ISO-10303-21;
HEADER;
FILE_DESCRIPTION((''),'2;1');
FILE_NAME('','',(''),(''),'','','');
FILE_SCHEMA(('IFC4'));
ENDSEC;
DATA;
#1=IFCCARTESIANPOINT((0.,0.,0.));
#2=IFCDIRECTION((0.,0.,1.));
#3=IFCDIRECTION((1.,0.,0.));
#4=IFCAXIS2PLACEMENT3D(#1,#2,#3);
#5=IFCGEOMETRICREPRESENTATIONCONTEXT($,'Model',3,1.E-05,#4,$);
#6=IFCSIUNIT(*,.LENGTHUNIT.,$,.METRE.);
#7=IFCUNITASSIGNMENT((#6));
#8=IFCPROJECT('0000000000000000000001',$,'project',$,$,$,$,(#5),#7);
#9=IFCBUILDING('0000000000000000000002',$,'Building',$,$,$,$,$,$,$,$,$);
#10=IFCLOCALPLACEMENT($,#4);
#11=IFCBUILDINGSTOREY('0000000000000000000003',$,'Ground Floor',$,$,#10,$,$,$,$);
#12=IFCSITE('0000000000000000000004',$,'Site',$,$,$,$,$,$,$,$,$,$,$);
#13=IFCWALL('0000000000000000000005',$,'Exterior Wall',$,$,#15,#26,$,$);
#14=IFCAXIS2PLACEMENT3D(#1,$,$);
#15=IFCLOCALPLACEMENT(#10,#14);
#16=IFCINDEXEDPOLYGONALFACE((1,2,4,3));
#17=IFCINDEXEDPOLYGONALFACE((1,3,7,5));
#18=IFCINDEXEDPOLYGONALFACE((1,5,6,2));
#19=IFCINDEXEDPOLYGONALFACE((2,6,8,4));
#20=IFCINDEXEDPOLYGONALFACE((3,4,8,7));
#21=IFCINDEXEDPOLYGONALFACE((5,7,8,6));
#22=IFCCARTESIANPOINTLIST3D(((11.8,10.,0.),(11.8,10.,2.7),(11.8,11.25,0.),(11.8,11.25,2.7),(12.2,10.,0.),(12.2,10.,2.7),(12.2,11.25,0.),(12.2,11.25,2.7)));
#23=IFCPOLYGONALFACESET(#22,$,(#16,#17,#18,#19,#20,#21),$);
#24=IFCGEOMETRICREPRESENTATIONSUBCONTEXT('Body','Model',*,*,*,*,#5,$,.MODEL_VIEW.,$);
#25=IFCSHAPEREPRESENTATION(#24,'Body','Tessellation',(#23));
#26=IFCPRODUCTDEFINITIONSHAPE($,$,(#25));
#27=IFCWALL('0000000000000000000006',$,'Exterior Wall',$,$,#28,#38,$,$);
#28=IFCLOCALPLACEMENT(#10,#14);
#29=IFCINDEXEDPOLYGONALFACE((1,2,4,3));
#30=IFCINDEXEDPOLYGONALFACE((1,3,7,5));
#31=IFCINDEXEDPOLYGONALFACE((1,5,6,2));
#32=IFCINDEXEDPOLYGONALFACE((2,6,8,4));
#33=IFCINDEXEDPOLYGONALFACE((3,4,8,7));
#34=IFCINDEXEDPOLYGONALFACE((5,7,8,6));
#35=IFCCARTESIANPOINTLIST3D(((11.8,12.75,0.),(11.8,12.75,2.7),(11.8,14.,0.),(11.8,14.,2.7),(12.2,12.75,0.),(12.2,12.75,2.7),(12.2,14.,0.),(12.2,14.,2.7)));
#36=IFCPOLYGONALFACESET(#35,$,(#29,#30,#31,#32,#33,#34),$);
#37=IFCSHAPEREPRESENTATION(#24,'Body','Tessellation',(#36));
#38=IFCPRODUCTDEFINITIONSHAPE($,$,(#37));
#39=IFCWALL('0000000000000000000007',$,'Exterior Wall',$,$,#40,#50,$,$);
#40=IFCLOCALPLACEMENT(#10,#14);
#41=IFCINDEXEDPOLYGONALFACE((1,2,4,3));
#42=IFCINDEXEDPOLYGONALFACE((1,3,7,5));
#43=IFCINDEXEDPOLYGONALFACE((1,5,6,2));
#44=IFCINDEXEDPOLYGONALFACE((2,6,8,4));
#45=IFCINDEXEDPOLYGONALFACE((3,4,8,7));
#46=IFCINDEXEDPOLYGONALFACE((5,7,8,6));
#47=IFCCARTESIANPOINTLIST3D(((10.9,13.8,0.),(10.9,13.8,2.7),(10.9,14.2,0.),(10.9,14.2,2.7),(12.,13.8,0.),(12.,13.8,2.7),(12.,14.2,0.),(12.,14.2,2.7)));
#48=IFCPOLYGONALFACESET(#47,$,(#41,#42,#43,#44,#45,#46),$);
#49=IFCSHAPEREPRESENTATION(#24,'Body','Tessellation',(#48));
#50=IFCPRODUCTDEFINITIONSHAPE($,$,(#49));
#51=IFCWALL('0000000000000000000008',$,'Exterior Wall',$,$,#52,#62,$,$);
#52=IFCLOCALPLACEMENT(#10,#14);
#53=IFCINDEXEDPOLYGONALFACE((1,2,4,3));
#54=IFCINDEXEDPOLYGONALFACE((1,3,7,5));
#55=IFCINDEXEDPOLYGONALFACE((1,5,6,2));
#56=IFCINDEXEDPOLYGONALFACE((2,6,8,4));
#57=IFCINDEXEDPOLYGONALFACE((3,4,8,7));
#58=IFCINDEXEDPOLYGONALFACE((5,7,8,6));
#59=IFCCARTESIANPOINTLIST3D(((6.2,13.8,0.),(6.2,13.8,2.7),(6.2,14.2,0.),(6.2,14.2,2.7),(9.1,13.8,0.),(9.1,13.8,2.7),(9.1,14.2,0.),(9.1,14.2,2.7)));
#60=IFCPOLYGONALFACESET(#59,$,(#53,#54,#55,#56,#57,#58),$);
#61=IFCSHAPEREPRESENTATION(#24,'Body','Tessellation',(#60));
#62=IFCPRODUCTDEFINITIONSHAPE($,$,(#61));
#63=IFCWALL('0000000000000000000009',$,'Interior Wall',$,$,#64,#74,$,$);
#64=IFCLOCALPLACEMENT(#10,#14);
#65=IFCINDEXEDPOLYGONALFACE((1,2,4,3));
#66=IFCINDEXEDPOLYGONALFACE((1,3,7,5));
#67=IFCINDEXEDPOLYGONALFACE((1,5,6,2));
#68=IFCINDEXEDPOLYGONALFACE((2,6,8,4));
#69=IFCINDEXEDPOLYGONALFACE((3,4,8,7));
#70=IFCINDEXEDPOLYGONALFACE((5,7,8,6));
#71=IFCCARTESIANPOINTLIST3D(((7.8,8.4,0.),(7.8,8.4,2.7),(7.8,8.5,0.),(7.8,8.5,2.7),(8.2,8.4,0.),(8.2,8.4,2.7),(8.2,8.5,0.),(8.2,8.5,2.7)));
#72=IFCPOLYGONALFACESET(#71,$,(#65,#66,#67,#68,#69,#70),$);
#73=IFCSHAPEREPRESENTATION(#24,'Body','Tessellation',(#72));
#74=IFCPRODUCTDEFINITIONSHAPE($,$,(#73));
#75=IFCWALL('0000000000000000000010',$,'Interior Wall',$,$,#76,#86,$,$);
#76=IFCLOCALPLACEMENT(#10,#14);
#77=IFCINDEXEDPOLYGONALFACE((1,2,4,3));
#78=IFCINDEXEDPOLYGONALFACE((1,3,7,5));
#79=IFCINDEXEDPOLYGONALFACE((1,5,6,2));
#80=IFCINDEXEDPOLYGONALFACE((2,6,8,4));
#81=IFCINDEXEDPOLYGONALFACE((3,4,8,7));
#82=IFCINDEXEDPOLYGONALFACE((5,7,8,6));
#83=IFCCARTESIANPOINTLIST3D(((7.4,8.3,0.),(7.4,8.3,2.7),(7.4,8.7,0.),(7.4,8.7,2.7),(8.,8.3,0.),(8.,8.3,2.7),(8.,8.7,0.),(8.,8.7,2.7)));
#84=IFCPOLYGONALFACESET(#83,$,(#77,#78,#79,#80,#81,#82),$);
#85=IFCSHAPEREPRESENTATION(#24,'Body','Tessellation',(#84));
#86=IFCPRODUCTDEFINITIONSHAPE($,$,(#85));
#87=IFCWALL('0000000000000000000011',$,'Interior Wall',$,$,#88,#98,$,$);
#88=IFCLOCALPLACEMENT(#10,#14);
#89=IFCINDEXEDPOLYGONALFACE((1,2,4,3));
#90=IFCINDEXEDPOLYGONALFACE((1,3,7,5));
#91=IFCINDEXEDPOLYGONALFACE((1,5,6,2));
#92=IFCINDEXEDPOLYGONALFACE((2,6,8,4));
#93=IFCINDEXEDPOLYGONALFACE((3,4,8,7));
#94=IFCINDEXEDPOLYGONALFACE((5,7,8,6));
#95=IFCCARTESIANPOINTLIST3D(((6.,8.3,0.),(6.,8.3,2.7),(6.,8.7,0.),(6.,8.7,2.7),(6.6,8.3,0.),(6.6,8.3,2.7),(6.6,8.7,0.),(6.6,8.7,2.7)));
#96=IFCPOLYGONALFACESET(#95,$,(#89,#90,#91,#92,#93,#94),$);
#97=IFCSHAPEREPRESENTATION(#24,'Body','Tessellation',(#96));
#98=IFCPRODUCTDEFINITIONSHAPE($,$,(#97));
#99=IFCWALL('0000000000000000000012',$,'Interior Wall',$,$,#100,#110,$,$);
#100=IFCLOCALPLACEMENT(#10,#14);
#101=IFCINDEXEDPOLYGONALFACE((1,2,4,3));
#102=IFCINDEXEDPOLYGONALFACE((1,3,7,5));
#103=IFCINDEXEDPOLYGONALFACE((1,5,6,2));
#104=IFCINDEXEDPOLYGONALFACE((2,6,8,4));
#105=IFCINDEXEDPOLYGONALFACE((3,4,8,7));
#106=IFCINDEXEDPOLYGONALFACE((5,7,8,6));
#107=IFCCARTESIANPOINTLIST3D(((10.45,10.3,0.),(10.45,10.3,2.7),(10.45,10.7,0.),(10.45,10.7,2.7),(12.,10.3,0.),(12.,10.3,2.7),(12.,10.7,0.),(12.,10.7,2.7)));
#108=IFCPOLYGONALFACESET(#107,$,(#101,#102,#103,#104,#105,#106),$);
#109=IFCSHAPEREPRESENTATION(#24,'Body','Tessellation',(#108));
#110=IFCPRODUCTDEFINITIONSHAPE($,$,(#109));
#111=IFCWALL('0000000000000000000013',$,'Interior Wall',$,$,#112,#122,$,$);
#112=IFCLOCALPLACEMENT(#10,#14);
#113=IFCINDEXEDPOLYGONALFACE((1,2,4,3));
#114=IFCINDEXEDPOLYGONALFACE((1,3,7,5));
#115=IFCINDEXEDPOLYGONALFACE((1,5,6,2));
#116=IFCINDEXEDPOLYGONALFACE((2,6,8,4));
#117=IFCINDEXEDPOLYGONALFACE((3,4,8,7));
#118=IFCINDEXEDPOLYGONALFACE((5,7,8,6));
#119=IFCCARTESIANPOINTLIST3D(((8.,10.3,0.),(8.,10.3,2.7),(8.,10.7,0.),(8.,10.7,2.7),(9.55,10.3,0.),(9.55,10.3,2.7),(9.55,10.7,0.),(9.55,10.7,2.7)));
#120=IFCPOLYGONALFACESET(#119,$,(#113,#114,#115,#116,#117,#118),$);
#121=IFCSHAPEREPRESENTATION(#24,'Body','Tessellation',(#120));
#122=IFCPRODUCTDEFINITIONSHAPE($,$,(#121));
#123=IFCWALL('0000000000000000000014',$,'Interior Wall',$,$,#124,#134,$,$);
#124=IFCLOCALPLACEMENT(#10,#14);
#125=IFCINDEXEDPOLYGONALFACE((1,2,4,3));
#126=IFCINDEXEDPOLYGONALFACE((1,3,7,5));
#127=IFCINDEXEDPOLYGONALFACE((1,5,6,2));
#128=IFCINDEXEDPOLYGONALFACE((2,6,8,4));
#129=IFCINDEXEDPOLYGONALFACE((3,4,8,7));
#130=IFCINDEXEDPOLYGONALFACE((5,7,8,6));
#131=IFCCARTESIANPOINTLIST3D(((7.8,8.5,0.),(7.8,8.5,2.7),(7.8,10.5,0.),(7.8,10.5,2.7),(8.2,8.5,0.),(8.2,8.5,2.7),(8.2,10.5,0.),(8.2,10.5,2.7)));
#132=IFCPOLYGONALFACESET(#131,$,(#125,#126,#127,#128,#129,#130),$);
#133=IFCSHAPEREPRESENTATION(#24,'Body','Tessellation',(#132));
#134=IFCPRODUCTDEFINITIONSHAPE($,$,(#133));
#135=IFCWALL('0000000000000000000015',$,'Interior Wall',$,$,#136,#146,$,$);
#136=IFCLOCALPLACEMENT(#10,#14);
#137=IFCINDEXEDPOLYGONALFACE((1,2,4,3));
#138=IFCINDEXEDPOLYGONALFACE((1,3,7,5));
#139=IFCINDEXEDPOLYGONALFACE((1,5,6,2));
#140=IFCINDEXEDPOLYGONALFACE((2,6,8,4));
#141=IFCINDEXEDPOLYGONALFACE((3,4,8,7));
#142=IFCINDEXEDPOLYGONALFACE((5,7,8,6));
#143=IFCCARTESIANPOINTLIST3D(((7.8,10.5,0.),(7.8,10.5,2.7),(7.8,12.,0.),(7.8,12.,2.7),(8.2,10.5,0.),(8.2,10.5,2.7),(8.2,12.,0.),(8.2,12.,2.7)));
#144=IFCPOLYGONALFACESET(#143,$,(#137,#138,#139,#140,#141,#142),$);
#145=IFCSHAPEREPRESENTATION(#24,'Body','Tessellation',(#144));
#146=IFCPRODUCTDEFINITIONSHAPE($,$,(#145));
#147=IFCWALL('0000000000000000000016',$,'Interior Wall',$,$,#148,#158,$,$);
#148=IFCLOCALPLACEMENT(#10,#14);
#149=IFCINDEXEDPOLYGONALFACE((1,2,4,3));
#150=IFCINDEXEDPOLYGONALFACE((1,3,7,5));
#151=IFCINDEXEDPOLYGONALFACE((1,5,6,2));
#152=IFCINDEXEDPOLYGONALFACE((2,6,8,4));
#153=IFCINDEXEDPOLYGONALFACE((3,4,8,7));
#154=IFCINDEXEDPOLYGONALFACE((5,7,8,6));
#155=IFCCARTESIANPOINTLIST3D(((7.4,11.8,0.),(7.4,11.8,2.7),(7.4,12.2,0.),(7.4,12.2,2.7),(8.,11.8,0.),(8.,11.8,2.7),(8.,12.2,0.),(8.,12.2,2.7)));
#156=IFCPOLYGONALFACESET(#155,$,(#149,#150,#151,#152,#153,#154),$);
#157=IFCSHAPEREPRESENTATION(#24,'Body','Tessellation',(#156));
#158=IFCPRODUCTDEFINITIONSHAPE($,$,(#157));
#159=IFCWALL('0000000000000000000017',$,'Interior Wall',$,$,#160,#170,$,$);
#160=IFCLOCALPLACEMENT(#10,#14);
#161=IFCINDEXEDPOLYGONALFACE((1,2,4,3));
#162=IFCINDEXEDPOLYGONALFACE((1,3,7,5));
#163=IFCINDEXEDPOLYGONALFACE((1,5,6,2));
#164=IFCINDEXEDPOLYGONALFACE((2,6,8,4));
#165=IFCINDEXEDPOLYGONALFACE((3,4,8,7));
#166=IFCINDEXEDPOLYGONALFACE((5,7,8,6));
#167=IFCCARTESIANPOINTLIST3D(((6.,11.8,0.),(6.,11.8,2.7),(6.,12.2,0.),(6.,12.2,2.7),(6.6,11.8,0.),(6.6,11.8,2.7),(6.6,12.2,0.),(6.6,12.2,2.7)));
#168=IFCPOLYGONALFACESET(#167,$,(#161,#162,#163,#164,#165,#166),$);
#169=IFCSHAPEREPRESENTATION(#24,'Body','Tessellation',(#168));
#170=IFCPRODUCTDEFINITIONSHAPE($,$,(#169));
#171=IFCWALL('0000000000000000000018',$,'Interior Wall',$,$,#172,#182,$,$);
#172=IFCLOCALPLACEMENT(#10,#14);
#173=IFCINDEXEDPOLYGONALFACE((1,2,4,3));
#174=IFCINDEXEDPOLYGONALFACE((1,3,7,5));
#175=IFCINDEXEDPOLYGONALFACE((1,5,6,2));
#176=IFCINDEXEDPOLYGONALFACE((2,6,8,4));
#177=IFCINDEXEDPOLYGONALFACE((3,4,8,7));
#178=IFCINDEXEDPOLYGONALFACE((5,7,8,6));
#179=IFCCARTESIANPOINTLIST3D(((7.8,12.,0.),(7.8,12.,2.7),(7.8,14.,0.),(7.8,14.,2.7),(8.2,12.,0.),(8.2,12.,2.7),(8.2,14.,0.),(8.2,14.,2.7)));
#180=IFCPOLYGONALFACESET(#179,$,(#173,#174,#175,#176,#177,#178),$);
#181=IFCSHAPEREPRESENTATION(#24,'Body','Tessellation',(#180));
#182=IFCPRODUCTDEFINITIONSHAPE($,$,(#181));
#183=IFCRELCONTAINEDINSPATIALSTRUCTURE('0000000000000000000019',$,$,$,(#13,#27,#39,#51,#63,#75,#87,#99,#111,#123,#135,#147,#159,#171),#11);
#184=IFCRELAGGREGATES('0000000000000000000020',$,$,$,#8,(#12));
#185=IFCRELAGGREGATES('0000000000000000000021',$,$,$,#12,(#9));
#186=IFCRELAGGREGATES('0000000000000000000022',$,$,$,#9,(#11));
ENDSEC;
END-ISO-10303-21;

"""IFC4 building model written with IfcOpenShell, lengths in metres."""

from ifc_helpers import new_model, si_unit, frame, origin_with_axes, place, context, subcontext, project, spatial, indexed_curve, outline, extrude, element, save


model = new_model("IFC4")

# Units and contexts
model_context = context("Model", 3, precision=1e-05, world=origin_with_axes())
body_context = subcontext(model_context, "Body", "Model", "MODEL_VIEW")
ifc_project = project(units=[si_unit("LENGTHUNIT", "METRE")], contexts=[model_context])

# Site, building, storey
site = spatial("IfcSite", under=ifc_project, Name="Site")
building = spatial("IfcBuilding", under=site, Name="Building")
storey_placement = place(None, origin_with_axes())
storey = spatial("IfcBuildingStorey", under=building, at=storey_placement, Name="Ground Floor")

# Walls
for number, where, z_axis, x_axis, name in (
    (1, (12.0, 10.0, 0.0), (0.0, 0.0, 1.0), (0.0, 1.0, 0.0), "Exterior Wall"),
    (2, (12.0, 12.75, 0.0), (0.0, 0.0, 1.0), (0.0, 1.0, 0.0), "Exterior Wall"),
):
    element("IfcWall", number, at=place(storey_placement, frame(where, z_axis=z_axis, x_axis=x_axis)), inside=storey, Name=name, context=body_context, shape_type="SweptSolid", body=[
        extrude(outline(indexed_curve([(0.0, 0.0), (0.0, 0.4), (1.25, 0.4), (1.25, 0.0), (0.0, 0.0)], self_intersect=False)), frame((0.0, -0.2, 0.0), z_axis=(0.0, 0.0, 1.0), x_axis=(1.0, 0.0, 0.0)), (0.0, 0.0, 1.0), 2.7),
    ])
wall_1_placement = place(storey_placement, frame((12.0, 14.0, 0.0), z_axis=(0.0, 0.0, 1.0), x_axis=(-1.0, 0.0, 0.0)))
element("IfcWall", 3, at=wall_1_placement, inside=storey, Name="Exterior Wall", context=body_context, shape_type="SweptSolid", body=[
    extrude(outline(indexed_curve([(0.0, 0.0), (0.0, 0.4), (1.1, 0.4), (1.1, 0.0), (0.0, 0.0)], self_intersect=False)), frame((0.0, -0.2, 0.0), z_axis=(0.0, 0.0, 1.0), x_axis=(1.0, 0.0, 0.0)), (0.0, 0.0, 1.0), 2.7),
])
wall_2_placement = place(storey_placement, frame((9.1, 14.0, 0.0), z_axis=(0.0, 0.0, 1.0), x_axis=(-1.0, 0.0, 0.0)))
element("IfcWall", 4, at=wall_2_placement, inside=storey, Name="Exterior Wall", context=body_context, shape_type="SweptSolid", body=[
    extrude(outline(indexed_curve([(0.0, 0.0), (0.0, 0.4), (2.9, 0.4), (2.9, 0.0), (0.0, 0.0)], self_intersect=False)), frame((0.0, -0.2, 0.0), z_axis=(0.0, 0.0, 1.0), x_axis=(1.0, 0.0, 0.0)), (0.0, 0.0, 1.0), 2.7),
])
wall_3_placement = place(storey_placement, frame((8.0, 8.4, 0.0), z_axis=(0.0, 0.0, 1.0), x_axis=(0.0, 1.0, 0.0)))
element("IfcWall", 5, at=wall_3_placement, inside=storey, Name="Interior Wall", context=body_context, shape_type="SweptSolid", body=[
    extrude(outline(indexed_curve([(0.0, 0.0), (0.0, 0.4), (0.1, 0.4), (0.1, 0.0), (0.0, 0.0)], self_intersect=False)), frame((0.0, -0.2, 0.0), z_axis=(0.0, 0.0, 1.0), x_axis=(1.0, 0.0, 0.0)), (0.0, 0.0, 1.0), 2.7),
])
for number, where, z_axis, x_axis, name in (
    (6, (8.0, 8.5, 0.0), (0.0, 0.0, 1.0), (-1.0, 0.0, 0.0), "Interior Wall"),
    (7, (6.6, 8.5, 0.0), (0.0, 0.0, 1.0), (-1.0, 0.0, 0.0), "Interior Wall"),
):
    element("IfcWall", number, at=place(storey_placement, frame(where, z_axis=z_axis, x_axis=x_axis)), inside=storey, Name=name, context=body_context, shape_type="SweptSolid", body=[
        extrude(outline(indexed_curve([(0.0, 0.0), (0.0, 0.4), (0.6, 0.4), (0.6, 0.0), (0.0, 0.0)], self_intersect=False)), frame((0.0, -0.2, 0.0), z_axis=(0.0, 0.0, 1.0), x_axis=(1.0, 0.0, 0.0)), (0.0, 0.0, 1.0), 2.7),
    ])
for number, where, z_axis, x_axis, name in (
    (8, (12.0, 10.5, 0.0), (0.0, 0.0, 1.0), (-1.0, 0.0, 0.0), "Interior Wall"),
    (9, (9.55, 10.5, 0.0), (0.0, 0.0, 1.0), (-1.0, 0.0, 0.0), "Interior Wall"),
):
    element("IfcWall", number, at=place(storey_placement, frame(where, z_axis=z_axis, x_axis=x_axis)), inside=storey, Name=name, context=body_context, shape_type="SweptSolid", body=[
        extrude(outline(indexed_curve([(0.0, 0.0), (0.0, 0.4), (1.55, 0.4), (1.55, 0.0), (0.0, 0.0)], self_intersect=False)), frame((0.0, -0.2, 0.0), z_axis=(0.0, 0.0, 1.0), x_axis=(1.0, 0.0, 0.0)), (0.0, 0.0, 1.0), 2.7),
    ])
wall_4_placement = place(storey_placement, frame((8.0, 10.5, 0.0), z_axis=(0.0, 0.0, 1.0), x_axis=(0.0, -1.0, 0.0)))
element("IfcWall", 10, at=wall_4_placement, inside=storey, Name="Interior Wall", context=body_context, shape_type="SweptSolid", body=[
    extrude(outline(indexed_curve([(0.0, 0.0), (0.0, 0.4), (2.0, 0.4), (2.0, 0.0), (0.0, 0.0)], self_intersect=False)), frame((0.0, -0.2, 0.0), z_axis=(0.0, 0.0, 1.0), x_axis=(1.0, 0.0, 0.0)), (0.0, 0.0, 1.0), 2.7),
])
wall_5_placement = place(storey_placement, frame((8.0, 10.5, 0.0), z_axis=(0.0, 0.0, 1.0), x_axis=(0.0, 1.0, 0.0)))
element("IfcWall", 11, at=wall_5_placement, inside=storey, Name="Interior Wall", context=body_context, shape_type="SweptSolid", body=[
    extrude(outline(indexed_curve([(0.0, 0.0), (0.0, 0.4), (1.5, 0.4), (1.5, 0.0), (0.0, 0.0)], self_intersect=False)), frame((0.0, -0.2, 0.0), z_axis=(0.0, 0.0, 1.0), x_axis=(1.0, 0.0, 0.0)), (0.0, 0.0, 1.0), 2.7),
])
for number, where, z_axis, x_axis, name in (
    (12, (8.0, 12.0, 0.0), (0.0, 0.0, 1.0), (-1.0, 0.0, 0.0), "Interior Wall"),
    (13, (6.6, 12.0, 0.0), (0.0, 0.0, 1.0), (-1.0, 0.0, 0.0), "Interior Wall"),
):
    element("IfcWall", number, at=place(storey_placement, frame(where, z_axis=z_axis, x_axis=x_axis)), inside=storey, Name=name, context=body_context, shape_type="SweptSolid", body=[
        extrude(outline(indexed_curve([(0.0, 0.0), (0.0, 0.4), (0.6, 0.4), (0.6, 0.0), (0.0, 0.0)], self_intersect=False)), frame((0.0, -0.2, 0.0), z_axis=(0.0, 0.0, 1.0), x_axis=(1.0, 0.0, 0.0)), (0.0, 0.0, 1.0), 2.7),
    ])
wall_6_placement = place(storey_placement, frame((8.0, 14.0, 0.0), z_axis=(0.0, 0.0, 1.0), x_axis=(0.0, -1.0, 0.0)))
element("IfcWall", 14, at=wall_6_placement, inside=storey, Name="Interior Wall", context=body_context, shape_type="SweptSolid", body=[
    extrude(outline(indexed_curve([(0.0, 0.0), (0.0, 0.4), (2.0, 0.4), (2.0, 0.0), (0.0, 0.0)], self_intersect=False)), frame((0.0, -0.2, 0.0), z_axis=(0.0, 0.0, 1.0), x_axis=(1.0, 0.0, 0.0)), (0.0, 0.0, 1.0), 2.7),
])

save(model, "model.ifc")
